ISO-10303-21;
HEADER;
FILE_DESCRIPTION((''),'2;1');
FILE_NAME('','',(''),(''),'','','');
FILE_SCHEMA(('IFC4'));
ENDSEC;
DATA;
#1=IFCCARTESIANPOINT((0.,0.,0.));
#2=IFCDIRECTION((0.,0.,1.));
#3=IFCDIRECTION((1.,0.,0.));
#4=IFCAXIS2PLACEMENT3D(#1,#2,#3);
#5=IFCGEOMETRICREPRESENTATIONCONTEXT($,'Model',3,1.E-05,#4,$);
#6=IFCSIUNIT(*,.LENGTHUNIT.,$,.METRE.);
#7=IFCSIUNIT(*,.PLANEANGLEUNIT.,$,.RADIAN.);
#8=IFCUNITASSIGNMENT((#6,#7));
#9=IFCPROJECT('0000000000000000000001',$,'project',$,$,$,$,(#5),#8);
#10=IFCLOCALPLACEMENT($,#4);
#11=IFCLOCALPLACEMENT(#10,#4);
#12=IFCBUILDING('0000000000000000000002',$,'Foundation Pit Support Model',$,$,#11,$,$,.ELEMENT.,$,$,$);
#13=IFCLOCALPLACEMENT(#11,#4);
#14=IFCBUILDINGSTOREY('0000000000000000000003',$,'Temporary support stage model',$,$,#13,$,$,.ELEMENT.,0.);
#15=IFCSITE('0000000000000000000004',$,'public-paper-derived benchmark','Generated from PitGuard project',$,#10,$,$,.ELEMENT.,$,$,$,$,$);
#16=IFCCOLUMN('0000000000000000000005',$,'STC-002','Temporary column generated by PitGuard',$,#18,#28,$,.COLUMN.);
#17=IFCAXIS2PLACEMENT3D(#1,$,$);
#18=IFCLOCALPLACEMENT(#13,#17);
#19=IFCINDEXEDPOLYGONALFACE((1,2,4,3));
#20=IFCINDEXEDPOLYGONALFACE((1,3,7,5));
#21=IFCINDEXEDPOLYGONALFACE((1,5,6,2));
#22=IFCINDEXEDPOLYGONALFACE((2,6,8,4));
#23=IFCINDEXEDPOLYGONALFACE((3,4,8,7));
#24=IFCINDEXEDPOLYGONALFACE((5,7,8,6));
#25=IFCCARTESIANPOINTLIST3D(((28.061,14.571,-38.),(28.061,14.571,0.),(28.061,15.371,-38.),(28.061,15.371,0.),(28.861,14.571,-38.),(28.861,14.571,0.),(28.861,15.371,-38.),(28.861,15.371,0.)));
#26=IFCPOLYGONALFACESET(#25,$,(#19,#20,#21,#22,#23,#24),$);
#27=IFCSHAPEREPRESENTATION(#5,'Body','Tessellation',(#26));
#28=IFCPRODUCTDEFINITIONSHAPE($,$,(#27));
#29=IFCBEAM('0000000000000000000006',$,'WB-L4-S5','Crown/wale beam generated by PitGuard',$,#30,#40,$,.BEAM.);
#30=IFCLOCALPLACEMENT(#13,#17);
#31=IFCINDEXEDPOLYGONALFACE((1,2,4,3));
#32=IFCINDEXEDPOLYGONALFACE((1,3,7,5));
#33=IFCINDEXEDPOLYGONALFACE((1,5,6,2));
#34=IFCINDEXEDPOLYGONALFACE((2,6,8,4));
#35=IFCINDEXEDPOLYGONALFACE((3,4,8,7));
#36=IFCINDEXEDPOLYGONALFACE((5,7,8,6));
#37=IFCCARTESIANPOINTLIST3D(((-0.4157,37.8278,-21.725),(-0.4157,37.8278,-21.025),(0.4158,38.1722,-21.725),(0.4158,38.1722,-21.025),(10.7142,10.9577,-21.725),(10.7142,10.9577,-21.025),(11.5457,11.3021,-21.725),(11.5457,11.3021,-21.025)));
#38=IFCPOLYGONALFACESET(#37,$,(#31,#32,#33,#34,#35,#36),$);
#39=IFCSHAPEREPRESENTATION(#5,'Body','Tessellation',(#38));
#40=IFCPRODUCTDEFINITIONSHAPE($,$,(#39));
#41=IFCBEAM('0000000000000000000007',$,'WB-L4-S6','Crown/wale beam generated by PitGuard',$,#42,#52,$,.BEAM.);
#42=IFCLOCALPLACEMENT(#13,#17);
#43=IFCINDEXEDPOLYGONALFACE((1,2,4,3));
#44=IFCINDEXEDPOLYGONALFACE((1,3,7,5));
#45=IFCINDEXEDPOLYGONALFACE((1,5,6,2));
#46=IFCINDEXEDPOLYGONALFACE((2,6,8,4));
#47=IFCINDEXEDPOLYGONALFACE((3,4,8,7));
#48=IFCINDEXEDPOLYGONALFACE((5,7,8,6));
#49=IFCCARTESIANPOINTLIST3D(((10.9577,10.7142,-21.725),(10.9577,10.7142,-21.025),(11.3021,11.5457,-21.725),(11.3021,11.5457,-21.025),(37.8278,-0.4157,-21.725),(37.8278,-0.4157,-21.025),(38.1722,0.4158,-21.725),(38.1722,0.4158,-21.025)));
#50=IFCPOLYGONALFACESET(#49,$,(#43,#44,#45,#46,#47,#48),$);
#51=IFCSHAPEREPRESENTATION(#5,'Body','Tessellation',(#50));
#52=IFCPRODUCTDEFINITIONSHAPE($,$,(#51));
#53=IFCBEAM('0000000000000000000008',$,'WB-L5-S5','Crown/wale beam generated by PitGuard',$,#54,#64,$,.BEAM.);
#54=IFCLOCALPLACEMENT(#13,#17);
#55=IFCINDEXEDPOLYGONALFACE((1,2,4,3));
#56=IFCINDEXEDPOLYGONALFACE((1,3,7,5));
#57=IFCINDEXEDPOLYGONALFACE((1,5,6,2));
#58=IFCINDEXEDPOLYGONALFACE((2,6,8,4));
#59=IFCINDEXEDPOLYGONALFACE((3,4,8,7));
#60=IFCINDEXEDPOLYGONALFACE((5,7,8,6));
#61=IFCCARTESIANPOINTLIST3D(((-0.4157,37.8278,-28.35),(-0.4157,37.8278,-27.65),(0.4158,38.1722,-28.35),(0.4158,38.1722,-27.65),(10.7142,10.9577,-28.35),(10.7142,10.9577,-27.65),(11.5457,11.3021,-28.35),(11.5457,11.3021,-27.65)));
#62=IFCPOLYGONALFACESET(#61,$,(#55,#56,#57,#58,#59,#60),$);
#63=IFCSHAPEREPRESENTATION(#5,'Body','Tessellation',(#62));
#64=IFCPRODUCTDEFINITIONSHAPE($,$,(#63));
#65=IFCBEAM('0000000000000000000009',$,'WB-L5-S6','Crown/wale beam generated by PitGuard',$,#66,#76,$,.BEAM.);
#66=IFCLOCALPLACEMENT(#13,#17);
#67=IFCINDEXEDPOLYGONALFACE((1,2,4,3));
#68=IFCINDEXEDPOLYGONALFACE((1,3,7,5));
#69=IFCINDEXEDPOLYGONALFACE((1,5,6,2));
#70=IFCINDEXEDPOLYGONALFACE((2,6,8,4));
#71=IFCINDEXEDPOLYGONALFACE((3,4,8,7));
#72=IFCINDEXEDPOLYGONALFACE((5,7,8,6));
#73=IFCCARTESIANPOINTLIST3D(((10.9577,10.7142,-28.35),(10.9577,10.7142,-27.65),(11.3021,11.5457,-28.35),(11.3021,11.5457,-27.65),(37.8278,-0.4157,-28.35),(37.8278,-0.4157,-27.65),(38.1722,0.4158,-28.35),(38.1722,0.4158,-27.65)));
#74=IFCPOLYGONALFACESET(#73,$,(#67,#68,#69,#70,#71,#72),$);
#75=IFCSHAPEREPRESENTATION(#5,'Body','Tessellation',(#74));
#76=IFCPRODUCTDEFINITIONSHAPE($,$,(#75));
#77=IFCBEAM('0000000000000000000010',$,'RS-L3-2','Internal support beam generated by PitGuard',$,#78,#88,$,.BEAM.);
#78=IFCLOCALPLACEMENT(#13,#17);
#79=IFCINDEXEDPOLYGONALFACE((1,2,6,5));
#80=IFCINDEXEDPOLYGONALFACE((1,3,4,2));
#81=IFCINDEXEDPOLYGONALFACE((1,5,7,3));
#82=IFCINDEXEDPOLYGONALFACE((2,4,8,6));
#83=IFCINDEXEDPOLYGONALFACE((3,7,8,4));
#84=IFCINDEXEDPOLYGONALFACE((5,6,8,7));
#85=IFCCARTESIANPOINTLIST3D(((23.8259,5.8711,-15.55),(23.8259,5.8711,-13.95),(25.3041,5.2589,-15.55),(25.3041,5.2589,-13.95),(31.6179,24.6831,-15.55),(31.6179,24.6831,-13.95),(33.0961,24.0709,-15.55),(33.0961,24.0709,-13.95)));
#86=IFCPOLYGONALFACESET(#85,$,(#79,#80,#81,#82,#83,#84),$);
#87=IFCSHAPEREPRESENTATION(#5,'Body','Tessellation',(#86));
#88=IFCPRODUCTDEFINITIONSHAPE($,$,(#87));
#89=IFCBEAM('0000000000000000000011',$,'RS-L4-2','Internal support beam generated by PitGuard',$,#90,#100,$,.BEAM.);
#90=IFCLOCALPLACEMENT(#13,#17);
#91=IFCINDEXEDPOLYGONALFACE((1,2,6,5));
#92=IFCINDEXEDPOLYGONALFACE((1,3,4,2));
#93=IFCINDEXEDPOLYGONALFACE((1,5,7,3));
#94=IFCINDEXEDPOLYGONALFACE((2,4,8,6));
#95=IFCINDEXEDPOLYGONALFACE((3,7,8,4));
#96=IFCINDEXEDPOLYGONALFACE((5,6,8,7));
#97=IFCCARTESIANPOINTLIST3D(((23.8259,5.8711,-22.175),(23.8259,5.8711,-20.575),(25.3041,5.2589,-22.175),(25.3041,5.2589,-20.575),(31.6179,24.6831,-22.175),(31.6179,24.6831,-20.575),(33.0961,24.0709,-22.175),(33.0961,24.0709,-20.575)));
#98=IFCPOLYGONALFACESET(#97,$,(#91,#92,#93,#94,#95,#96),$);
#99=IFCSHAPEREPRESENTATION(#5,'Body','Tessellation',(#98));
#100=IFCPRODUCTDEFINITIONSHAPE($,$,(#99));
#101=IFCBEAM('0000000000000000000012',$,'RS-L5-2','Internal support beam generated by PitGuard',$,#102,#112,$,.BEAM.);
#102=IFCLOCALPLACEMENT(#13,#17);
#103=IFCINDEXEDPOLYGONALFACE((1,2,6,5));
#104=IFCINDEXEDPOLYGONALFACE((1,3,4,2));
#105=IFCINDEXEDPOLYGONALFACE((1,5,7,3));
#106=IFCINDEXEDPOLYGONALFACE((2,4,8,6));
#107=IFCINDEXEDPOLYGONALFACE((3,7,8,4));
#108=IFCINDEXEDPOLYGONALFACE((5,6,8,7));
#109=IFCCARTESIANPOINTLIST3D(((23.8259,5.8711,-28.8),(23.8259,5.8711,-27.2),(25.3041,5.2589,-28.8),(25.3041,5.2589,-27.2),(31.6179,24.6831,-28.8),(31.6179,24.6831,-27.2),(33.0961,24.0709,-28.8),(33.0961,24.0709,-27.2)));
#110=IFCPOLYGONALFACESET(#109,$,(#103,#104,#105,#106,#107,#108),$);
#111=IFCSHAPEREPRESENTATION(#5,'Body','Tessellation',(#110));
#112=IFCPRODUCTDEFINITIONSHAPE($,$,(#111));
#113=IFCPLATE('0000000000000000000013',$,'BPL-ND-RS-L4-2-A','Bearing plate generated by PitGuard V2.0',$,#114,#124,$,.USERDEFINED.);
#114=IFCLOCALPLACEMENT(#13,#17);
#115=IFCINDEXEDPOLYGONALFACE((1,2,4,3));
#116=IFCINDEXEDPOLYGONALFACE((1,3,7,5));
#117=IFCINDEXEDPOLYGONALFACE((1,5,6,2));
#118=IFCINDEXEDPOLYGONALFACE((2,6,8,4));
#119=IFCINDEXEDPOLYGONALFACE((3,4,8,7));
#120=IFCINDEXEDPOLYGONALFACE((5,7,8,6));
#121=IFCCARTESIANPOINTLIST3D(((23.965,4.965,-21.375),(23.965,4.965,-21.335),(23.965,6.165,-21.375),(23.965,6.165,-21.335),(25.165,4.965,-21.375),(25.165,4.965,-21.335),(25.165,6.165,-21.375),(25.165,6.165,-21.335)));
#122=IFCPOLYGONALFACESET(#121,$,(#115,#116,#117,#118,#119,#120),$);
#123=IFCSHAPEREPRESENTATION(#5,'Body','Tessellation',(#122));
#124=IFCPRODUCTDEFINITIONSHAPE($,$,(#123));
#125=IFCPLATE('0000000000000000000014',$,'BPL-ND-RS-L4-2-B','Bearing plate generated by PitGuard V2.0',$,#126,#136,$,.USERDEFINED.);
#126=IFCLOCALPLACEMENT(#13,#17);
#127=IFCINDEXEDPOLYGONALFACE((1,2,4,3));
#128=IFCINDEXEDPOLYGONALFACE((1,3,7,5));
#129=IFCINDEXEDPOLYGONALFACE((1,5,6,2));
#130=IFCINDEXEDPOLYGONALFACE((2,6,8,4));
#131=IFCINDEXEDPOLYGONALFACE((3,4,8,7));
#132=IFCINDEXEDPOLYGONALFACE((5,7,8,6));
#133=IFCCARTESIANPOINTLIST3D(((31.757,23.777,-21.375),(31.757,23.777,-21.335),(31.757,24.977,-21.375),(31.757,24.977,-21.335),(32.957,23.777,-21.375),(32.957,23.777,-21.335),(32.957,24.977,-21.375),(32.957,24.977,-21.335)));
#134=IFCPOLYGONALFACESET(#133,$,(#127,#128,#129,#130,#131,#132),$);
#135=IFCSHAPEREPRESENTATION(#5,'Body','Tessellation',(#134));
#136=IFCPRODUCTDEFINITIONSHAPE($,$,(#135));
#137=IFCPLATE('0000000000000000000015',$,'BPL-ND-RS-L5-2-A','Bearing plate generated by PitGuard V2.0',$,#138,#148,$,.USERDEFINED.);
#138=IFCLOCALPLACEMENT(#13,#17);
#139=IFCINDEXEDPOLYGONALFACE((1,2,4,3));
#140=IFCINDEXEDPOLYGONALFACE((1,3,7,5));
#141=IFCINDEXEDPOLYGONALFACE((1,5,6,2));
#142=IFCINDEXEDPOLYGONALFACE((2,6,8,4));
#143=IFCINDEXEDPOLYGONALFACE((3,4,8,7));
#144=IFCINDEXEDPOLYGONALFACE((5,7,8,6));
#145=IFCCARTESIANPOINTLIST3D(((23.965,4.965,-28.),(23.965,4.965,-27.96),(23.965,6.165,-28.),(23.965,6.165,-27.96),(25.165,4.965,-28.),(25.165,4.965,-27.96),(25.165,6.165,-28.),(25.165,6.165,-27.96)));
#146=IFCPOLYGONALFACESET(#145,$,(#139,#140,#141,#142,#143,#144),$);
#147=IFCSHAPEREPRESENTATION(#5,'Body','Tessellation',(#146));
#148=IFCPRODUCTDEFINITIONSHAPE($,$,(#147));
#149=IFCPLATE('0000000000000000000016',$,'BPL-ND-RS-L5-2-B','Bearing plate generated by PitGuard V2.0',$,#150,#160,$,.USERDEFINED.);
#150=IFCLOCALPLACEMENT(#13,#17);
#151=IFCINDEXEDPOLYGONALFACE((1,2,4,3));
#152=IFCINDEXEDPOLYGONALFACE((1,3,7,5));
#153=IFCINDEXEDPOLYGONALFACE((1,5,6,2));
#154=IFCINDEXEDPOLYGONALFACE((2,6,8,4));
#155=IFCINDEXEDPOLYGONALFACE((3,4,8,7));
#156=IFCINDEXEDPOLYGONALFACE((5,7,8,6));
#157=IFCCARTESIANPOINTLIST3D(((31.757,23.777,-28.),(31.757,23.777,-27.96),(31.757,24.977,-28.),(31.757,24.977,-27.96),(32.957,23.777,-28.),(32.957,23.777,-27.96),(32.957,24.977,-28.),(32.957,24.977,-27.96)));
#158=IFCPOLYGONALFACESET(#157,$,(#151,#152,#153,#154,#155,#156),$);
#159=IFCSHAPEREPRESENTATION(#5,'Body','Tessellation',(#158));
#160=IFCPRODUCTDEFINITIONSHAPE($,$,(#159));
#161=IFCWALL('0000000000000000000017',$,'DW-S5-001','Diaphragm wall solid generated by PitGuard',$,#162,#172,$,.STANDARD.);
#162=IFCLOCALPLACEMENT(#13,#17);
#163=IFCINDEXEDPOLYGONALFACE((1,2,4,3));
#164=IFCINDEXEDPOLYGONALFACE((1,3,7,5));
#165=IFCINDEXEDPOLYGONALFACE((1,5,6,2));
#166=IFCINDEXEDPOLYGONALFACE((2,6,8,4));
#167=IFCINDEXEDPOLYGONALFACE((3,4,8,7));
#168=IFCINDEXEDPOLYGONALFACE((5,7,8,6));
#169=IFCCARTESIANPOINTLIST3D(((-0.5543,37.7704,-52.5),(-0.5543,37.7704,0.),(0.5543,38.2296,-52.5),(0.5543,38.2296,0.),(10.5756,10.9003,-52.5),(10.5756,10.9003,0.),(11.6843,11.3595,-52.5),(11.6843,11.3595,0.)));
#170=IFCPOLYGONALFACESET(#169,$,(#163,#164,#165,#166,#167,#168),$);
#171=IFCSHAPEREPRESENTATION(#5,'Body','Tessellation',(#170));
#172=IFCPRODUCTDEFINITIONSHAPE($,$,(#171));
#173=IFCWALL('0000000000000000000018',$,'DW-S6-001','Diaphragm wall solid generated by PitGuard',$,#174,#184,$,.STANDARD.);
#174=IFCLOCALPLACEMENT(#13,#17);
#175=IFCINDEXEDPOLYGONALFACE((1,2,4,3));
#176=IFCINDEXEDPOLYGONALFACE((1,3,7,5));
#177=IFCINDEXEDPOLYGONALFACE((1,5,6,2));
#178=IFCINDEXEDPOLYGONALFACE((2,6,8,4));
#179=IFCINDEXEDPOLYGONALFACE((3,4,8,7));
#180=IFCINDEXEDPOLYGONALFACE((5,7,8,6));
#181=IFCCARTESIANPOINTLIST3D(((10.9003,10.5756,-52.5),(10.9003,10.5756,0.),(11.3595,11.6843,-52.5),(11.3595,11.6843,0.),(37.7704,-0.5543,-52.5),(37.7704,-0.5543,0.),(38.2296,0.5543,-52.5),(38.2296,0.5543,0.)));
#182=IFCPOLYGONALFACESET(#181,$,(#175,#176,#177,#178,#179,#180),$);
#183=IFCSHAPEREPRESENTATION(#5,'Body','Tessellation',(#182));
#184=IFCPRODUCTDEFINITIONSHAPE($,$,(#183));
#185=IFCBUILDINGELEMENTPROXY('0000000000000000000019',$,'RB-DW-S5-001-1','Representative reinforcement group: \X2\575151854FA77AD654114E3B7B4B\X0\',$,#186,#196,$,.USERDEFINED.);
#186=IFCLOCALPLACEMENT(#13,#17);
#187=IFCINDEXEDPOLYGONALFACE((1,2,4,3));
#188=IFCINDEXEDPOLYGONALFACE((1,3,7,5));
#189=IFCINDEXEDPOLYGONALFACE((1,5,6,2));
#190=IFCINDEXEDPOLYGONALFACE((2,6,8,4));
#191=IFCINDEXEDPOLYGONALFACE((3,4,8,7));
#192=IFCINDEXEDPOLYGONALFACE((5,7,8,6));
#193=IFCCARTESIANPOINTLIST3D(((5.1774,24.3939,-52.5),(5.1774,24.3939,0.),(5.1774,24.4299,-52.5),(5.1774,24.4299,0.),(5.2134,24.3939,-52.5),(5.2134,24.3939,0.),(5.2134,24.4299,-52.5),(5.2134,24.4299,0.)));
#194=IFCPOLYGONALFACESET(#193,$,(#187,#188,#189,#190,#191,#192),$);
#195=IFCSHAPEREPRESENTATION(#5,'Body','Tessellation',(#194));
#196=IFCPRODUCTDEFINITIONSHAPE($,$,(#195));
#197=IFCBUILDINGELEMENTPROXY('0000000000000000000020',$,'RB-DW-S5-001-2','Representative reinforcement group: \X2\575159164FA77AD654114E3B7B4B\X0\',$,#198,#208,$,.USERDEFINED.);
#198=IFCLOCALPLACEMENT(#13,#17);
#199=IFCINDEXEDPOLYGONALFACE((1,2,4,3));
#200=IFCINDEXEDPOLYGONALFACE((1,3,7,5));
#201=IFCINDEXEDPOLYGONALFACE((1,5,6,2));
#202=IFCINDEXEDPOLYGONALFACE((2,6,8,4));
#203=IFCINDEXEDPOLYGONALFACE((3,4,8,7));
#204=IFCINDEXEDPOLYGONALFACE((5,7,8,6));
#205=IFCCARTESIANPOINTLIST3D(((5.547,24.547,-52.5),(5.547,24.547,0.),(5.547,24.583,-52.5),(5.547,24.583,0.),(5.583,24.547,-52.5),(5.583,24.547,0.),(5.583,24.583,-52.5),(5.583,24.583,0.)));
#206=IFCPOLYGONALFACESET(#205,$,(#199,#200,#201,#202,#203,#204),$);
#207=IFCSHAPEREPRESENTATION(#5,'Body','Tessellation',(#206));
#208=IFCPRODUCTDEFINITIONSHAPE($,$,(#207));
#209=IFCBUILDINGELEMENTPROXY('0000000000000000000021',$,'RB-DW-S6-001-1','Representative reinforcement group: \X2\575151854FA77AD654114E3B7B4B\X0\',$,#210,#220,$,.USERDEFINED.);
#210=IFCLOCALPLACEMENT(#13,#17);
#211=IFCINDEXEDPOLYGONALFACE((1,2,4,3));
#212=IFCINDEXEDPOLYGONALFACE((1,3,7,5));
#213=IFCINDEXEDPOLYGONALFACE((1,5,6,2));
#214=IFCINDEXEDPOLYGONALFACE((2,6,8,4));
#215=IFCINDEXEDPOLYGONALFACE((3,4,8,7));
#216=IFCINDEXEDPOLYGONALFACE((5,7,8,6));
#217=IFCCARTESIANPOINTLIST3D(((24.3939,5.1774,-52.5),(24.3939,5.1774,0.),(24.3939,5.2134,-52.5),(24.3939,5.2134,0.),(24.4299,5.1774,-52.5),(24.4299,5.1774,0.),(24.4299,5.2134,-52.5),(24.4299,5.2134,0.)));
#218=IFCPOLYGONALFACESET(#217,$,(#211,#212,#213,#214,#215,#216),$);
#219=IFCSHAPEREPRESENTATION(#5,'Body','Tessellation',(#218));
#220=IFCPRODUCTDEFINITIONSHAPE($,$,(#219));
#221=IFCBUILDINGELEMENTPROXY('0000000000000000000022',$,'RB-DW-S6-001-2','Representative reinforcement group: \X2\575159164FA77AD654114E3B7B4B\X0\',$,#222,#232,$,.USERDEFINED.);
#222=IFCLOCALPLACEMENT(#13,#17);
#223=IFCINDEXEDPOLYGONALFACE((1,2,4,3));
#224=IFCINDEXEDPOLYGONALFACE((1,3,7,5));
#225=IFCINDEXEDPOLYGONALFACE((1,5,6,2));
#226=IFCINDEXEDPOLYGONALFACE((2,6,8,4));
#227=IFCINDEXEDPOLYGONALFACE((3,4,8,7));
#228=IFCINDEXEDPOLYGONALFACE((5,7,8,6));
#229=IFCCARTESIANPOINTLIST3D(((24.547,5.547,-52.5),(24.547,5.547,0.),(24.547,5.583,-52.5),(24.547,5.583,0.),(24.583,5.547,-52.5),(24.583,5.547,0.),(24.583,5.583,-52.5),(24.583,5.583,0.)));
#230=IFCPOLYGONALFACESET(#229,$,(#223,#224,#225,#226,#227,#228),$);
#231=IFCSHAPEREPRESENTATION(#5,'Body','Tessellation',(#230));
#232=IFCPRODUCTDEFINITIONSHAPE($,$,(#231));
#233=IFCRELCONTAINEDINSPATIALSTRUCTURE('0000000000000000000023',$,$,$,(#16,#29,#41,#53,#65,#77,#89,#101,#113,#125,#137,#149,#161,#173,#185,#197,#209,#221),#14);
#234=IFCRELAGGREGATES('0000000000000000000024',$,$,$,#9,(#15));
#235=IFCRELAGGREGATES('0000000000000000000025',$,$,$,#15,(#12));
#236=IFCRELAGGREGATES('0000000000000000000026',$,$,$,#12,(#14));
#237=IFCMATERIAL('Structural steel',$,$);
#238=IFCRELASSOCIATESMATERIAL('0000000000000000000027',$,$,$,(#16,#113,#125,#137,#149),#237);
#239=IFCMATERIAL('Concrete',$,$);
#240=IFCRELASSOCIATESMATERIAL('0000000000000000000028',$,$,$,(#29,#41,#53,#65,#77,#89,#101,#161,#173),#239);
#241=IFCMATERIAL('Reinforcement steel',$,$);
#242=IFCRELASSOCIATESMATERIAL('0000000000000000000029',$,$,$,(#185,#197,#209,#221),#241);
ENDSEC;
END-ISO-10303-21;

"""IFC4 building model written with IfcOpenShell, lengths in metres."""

from ifc_helpers import new_model, si_unit, frame, origin_with_axes, origin_2d, place, context, project, spatial, rectangle, extrude, material, element, save


model = new_model("IFC4")

# Units and contexts
model_context = context("Model", 3, precision=1e-05, world=origin_with_axes())
ifc_project = project(units=[si_unit("LENGTHUNIT", "METRE"), si_unit("PLANEANGLEUNIT", "RADIAN")], contexts=[model_context])

# Site, building, storey
site_placement = place(None, origin_with_axes())
site = spatial("IfcSite", under=ifc_project, at=site_placement, Name="public-paper-derived benchmark", Description="Generated from PitGuard project", CompositionType="ELEMENT")
building_placement = place(site_placement, origin_with_axes())
building = spatial("IfcBuilding", under=site, at=building_placement, Name="Foundation Pit Support Model", CompositionType="ELEMENT")
storey_placement = place(building_placement, origin_with_axes())
storey = spatial("IfcBuildingStorey", under=building, at=storey_placement, Name="Temporary support stage model", CompositionType="ELEMENT", Elevation=0.0)

# Column
ifc_material_1 = material(Name="Structural steel")
column_placement = place(storey_placement, frame((28.461, 14.971, -38.0), z_axis=(0.0, 0.0, 1.0), x_axis=(1.0, 0.0, 0.0)))
element("IfcColumn", 1, at=column_placement, inside=storey, material=ifc_material_1, Name="STC-002", Description="Temporary column generated by PitGuard", PredefinedType="COLUMN", context=model_context, shape_type="SweptSolid", body=[
    extrude(rectangle(XDim=0.8, YDim=0.8, at=origin_2d()), origin_with_axes(), (0.0, 0.0, 1.0), 38.0),
])

# Beams
ifc_material_2 = material(Name="Concrete")
for number, where, z_axis, x_axis, name in (
    (2, (5.565, 24.565, -21.725), (0.0, 0.0, 1.0), (0.382683, -0.92388, 0.0), "WB-L4-S5"),
    (3, (24.565, 5.565, -21.725), (0.0, 0.0, 1.0), (0.92388, -0.382683, 0.0), "WB-L4-S6"),
    (4, (5.565, 24.565, -28.35), (0.0, 0.0, 1.0), (0.382683, -0.92388, 0.0), "WB-L5-S5"),
    (5, (24.565, 5.565, -28.35), (0.0, 0.0, 1.0), (0.92388, -0.382683, 0.0), "WB-L5-S6"),
):
    element("IfcBeam", number, at=place(storey_placement, frame(where, z_axis=z_axis, x_axis=x_axis)), inside=storey, material=ifc_material_2, Name=name, Description="Crown/wale beam generated by PitGuard", PredefinedType="BEAM", context=model_context, shape_type="SweptSolid", body=[
        extrude(rectangle(XDim=29.0839, YDim=0.9, at=origin_2d()), origin_with_axes(), (0.0, 0.0, 1.0), 0.7),
    ])
for number, where, z_axis, x_axis, name in (
    (6, (28.461, 14.971, -15.55), (0.0, 0.0, 1.0), (0.382676, 0.923883, 0.0), "RS-L3-2"),
    (7, (28.461, 14.971, -22.175), (0.0, 0.0, 1.0), (0.382676, 0.923883, 0.0), "RS-L4-2"),
    (8, (28.461, 14.971, -28.8), (0.0, 0.0, 1.0), (0.382676, 0.923883, 0.0), "RS-L5-2"),
):
    element("IfcBeam", number, at=place(storey_placement, frame(where, z_axis=z_axis, x_axis=x_axis)), inside=storey, material=ifc_material_2, Name=name, Description="Internal support beam generated by PitGuard", PredefinedType="BEAM", context=model_context, shape_type="SweptSolid", body=[
        extrude(rectangle(XDim=20.3619, YDim=1.6, at=origin_2d()), origin_with_axes(), (0.0, 0.0, 1.0), 1.6),
    ])

# Plates
for number, where, z_axis, x_axis, name in (
    (9, (24.565, 5.565, -21.375), (0.0, 0.0, 1.0), (1.0, 0.0, 0.0), "BPL-ND-RS-L4-2-A"),
    (10, (32.357, 24.377, -21.375), (0.0, 0.0, 1.0), (1.0, 0.0, 0.0), "BPL-ND-RS-L4-2-B"),
    (11, (24.565, 5.565, -28.0), (0.0, 0.0, 1.0), (1.0, 0.0, 0.0), "BPL-ND-RS-L5-2-A"),
    (12, (32.357, 24.377, -28.0), (0.0, 0.0, 1.0), (1.0, 0.0, 0.0), "BPL-ND-RS-L5-2-B"),
):
    element("IfcPlate", number, at=place(storey_placement, frame(where, z_axis=z_axis, x_axis=x_axis)), inside=storey, material=ifc_material_1, Name=name, Description="Bearing plate generated by PitGuard V2.0", PredefinedType="USERDEFINED", context=model_context, shape_type="SweptSolid", body=[
        extrude(rectangle(XDim=1.2, YDim=1.2, at=origin_2d()), origin_with_axes(), (0.0, 0.0, 1.0), 0.04),
    ])

# Walls
for number, where, z_axis, x_axis, name in (
    (13, (5.565, 24.565, -52.5), (0.0, 0.0, 1.0), (0.382683, -0.92388, 0.0), "DW-S5-001"),
    (14, (24.565, 5.565, -52.5), (0.0, 0.0, 1.0), (0.92388, -0.382683, 0.0), "DW-S6-001"),
):
    element("IfcWall", number, at=place(storey_placement, frame(where, z_axis=z_axis, x_axis=x_axis)), inside=storey, material=ifc_material_2, Name=name, Description="Diaphragm wall solid generated by PitGuard", PredefinedType="STANDARD", context=model_context, shape_type="SweptSolid", body=[
        extrude(rectangle(XDim=29.0839, YDim=1.2, at=origin_2d()), origin_with_axes(), (0.0, 0.0, 1.0), 52.5),
    ])

# Building element proxies
ifc_material_3 = material(Name="Reinforcement steel")
for number, where, z_axis, x_axis, name, description in (
    (15, (5.1954, 24.4119, -52.5), (0.0, 0.0, 1.0), (1.0, 0.0, 0.0), "RB-DW-S5-001-1", "Representative reinforcement group: 坑内侧竖向主筋"),
    (16, (5.565, 24.565, -52.5), (0.0, 0.0, 1.0), (1.0, 0.0, 0.0), "RB-DW-S5-001-2", "Representative reinforcement group: 坑外侧竖向主筋"),
    (17, (24.4119, 5.1954, -52.5), (0.0, 0.0, 1.0), (1.0, 0.0, 0.0), "RB-DW-S6-001-1", "Representative reinforcement group: 坑内侧竖向主筋"),
    (18, (24.565, 5.565, -52.5), (0.0, 0.0, 1.0), (1.0, 0.0, 0.0), "RB-DW-S6-001-2", "Representative reinforcement group: 坑外侧竖向主筋"),
):
    element("IfcBuildingElementProxy", number, at=place(storey_placement, frame(where, z_axis=z_axis, x_axis=x_axis)), inside=storey, material=ifc_material_3, Name=name, Description=description, PredefinedType="USERDEFINED", context=model_context, shape_type="SweptSolid", body=[
        extrude(rectangle(XDim=0.036, YDim=0.036, at=origin_2d()), origin_with_axes(), (0.0, 0.0, 1.0), 52.5),
    ])

save(model, "model.ifc")
